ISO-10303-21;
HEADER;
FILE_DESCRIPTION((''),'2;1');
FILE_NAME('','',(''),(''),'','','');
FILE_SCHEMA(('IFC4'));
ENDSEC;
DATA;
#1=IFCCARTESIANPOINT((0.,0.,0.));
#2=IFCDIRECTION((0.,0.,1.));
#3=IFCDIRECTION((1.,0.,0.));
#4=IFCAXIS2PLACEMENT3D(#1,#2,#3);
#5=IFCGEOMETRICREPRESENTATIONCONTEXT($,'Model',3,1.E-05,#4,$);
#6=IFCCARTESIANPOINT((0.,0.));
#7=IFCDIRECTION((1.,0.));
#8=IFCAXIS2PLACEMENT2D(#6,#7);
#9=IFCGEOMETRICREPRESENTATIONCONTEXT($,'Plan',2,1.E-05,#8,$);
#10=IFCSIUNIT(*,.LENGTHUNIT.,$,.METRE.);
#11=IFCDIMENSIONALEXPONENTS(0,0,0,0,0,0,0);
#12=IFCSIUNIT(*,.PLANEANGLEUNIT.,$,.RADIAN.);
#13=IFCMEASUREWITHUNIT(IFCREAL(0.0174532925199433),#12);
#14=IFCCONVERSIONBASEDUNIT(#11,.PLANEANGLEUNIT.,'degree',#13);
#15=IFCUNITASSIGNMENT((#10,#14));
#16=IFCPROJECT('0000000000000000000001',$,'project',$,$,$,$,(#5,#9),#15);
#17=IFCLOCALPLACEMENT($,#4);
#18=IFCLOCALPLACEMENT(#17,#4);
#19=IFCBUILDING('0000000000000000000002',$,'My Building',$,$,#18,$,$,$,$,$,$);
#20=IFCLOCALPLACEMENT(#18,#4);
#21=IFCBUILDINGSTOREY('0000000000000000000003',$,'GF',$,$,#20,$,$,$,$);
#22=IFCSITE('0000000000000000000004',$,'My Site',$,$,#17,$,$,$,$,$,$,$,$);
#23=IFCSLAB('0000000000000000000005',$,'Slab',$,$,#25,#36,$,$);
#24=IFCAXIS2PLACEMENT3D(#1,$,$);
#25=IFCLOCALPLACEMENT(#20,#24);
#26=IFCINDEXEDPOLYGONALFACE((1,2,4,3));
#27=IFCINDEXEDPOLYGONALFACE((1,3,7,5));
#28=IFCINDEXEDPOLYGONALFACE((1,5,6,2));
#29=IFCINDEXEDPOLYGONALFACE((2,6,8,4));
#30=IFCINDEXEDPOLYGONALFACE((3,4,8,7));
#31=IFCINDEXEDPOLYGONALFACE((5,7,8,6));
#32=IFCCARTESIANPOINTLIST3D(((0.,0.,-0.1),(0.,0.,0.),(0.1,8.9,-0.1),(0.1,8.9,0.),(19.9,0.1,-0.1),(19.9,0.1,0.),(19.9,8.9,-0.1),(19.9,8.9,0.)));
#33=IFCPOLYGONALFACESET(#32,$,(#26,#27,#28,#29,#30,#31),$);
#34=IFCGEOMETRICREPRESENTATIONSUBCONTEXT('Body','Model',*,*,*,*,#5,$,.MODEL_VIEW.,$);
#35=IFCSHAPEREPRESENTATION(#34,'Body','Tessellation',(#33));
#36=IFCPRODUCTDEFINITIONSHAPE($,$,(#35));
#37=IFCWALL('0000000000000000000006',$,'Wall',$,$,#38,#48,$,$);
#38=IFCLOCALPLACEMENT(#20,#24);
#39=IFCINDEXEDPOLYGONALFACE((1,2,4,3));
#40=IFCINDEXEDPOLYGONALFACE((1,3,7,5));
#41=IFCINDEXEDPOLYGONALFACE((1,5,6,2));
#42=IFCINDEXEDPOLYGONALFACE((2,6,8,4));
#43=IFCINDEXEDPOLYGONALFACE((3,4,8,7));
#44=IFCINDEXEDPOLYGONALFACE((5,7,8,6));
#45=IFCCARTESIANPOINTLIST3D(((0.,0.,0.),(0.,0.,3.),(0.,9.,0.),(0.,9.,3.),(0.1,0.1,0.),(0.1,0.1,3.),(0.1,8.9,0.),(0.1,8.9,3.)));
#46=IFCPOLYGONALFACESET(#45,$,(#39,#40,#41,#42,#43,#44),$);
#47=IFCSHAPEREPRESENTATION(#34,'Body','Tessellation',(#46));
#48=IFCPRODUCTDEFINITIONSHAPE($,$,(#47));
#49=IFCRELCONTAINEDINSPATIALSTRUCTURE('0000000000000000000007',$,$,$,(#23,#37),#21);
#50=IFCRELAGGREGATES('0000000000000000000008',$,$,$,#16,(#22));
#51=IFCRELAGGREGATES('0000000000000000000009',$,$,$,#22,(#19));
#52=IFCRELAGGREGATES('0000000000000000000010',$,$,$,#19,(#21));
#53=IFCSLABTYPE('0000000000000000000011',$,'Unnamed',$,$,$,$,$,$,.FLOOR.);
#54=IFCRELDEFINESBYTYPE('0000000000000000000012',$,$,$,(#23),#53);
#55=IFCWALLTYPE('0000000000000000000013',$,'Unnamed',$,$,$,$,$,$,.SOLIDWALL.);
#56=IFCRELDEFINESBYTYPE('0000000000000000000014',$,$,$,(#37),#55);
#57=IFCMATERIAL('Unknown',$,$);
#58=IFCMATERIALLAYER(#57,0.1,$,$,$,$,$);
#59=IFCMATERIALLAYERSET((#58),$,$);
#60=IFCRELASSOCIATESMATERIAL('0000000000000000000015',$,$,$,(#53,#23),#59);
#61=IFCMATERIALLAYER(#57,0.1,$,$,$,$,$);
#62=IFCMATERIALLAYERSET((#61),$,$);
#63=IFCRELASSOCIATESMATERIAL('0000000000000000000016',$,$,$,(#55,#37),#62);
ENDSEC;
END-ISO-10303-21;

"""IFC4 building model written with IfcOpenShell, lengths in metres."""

from ifc_helpers import new_model, entity, si_unit, converted_unit, frame, origin_with_axes, origin_2d_with_axis, place, context, subcontext, project, spatial, line, indexed_curve, outline, extrude, material, layer, layer_set, layer_usage, type_object, element, save


model = new_model("IFC4")

# Units and contexts
model_context = context("Model", 3, precision=1e-05, world=origin_with_axes())
plan_context = context("Plan", 2, precision=1e-05, world=origin_2d_with_axis())
body_context_1 = subcontext(model_context, "Body", "Model", "MODEL_VIEW")
ifc_project = project(units=[si_unit("LENGTHUNIT", "METRE"), converted_unit("PLANEANGLEUNIT", "degree", entity("IfcReal", 0.0174532925199433), si_unit("PLANEANGLEUNIT", "RADIAN"), dimensions=[0, 0, 0, 0, 0, 0, 0])], contexts=[model_context, plan_context])

# Site, building, storey
site_placement = place(None, origin_with_axes())
site = spatial("IfcSite", under=ifc_project, at=site_placement, Name="My Site")
building_placement = place(site_placement, origin_with_axes())
building = spatial("IfcBuilding", under=site, at=building_placement, Name="My Building")
storey_placement = place(building_placement, origin_with_axes())
storey = spatial("IfcBuildingStorey", under=building, at=storey_placement, Name="GF")

# Slab
ifc_material = material(Name="Unknown")
ifc_layer_1 = layer(ifc_material, 0.1)
ifc_layer_set_1 = layer_set([ifc_layer_1])
ifc_layer_usage_1 = layer_usage(ifc_layer_set_1, "AXIS3", "POSITIVE", -0.1)
slab_type = type_object("IfcSlabType", Name="Unnamed", PredefinedType="FLOOR", material=ifc_layer_set_1)
slab_placement = place(storey_placement, frame((0.1, 8.9, 0.0), z_axis=(0.0, 0.0, 1.0), x_axis=(1.0, 0.0, 0.0)))
element("IfcSlab", 1, at=slab_placement, inside=storey, type_object=slab_type, material=ifc_layer_usage_1, Name="Slab", context=body_context_1, shape_type="SweptSolid", body=[
    extrude(outline(indexed_curve([(0.0, 0.0), (19.8, 0.0), (19.8, -8.8), (-0.1, -8.9), (0.0, 0.0)])), frame((0.0, 0.0, -0.1), z_axis=(0.0, 0.0, 1.0), x_axis=(1.0, 0.0, 0.0)), (0.0, 0.0, 1.0), 0.1),
])

# Shared definitions
ifc_layer_2 = layer(ifc_material, 0.1)
ifc_layer_set_2 = layer_set([ifc_layer_2])
wall_type = type_object("IfcWallType", Name="Unnamed", PredefinedType="SOLIDWALL", material=ifc_layer_set_2)

# Wall
ifc_layer_usage_2 = layer_usage(ifc_layer_set_2, "AXIS2", "POSITIVE", 0.0)
wall_1_placement = place(storey_placement, frame((0.0, 9.0, 0.0), z_axis=(0.0, 0.0, 1.0), x_axis=(0.0, -1.0, 0.0)))
element("IfcWall", 2, at=wall_1_placement, inside=storey, type_object=wall_type, material=ifc_layer_usage_2, Name="Wall", context=body_context_1, shape_type="SweptSolid", body=[
    extrude(outline(indexed_curve([(0.0, 0.0), (0.1, 0.1), (8.9, 0.1), (9.0, 0.0)], segments=[line(1, 2, 3, 4, 1)])), origin_with_axes(), (0.0, 0.0, 1.0), 3.0),
])

save(model, "model.ifc")
